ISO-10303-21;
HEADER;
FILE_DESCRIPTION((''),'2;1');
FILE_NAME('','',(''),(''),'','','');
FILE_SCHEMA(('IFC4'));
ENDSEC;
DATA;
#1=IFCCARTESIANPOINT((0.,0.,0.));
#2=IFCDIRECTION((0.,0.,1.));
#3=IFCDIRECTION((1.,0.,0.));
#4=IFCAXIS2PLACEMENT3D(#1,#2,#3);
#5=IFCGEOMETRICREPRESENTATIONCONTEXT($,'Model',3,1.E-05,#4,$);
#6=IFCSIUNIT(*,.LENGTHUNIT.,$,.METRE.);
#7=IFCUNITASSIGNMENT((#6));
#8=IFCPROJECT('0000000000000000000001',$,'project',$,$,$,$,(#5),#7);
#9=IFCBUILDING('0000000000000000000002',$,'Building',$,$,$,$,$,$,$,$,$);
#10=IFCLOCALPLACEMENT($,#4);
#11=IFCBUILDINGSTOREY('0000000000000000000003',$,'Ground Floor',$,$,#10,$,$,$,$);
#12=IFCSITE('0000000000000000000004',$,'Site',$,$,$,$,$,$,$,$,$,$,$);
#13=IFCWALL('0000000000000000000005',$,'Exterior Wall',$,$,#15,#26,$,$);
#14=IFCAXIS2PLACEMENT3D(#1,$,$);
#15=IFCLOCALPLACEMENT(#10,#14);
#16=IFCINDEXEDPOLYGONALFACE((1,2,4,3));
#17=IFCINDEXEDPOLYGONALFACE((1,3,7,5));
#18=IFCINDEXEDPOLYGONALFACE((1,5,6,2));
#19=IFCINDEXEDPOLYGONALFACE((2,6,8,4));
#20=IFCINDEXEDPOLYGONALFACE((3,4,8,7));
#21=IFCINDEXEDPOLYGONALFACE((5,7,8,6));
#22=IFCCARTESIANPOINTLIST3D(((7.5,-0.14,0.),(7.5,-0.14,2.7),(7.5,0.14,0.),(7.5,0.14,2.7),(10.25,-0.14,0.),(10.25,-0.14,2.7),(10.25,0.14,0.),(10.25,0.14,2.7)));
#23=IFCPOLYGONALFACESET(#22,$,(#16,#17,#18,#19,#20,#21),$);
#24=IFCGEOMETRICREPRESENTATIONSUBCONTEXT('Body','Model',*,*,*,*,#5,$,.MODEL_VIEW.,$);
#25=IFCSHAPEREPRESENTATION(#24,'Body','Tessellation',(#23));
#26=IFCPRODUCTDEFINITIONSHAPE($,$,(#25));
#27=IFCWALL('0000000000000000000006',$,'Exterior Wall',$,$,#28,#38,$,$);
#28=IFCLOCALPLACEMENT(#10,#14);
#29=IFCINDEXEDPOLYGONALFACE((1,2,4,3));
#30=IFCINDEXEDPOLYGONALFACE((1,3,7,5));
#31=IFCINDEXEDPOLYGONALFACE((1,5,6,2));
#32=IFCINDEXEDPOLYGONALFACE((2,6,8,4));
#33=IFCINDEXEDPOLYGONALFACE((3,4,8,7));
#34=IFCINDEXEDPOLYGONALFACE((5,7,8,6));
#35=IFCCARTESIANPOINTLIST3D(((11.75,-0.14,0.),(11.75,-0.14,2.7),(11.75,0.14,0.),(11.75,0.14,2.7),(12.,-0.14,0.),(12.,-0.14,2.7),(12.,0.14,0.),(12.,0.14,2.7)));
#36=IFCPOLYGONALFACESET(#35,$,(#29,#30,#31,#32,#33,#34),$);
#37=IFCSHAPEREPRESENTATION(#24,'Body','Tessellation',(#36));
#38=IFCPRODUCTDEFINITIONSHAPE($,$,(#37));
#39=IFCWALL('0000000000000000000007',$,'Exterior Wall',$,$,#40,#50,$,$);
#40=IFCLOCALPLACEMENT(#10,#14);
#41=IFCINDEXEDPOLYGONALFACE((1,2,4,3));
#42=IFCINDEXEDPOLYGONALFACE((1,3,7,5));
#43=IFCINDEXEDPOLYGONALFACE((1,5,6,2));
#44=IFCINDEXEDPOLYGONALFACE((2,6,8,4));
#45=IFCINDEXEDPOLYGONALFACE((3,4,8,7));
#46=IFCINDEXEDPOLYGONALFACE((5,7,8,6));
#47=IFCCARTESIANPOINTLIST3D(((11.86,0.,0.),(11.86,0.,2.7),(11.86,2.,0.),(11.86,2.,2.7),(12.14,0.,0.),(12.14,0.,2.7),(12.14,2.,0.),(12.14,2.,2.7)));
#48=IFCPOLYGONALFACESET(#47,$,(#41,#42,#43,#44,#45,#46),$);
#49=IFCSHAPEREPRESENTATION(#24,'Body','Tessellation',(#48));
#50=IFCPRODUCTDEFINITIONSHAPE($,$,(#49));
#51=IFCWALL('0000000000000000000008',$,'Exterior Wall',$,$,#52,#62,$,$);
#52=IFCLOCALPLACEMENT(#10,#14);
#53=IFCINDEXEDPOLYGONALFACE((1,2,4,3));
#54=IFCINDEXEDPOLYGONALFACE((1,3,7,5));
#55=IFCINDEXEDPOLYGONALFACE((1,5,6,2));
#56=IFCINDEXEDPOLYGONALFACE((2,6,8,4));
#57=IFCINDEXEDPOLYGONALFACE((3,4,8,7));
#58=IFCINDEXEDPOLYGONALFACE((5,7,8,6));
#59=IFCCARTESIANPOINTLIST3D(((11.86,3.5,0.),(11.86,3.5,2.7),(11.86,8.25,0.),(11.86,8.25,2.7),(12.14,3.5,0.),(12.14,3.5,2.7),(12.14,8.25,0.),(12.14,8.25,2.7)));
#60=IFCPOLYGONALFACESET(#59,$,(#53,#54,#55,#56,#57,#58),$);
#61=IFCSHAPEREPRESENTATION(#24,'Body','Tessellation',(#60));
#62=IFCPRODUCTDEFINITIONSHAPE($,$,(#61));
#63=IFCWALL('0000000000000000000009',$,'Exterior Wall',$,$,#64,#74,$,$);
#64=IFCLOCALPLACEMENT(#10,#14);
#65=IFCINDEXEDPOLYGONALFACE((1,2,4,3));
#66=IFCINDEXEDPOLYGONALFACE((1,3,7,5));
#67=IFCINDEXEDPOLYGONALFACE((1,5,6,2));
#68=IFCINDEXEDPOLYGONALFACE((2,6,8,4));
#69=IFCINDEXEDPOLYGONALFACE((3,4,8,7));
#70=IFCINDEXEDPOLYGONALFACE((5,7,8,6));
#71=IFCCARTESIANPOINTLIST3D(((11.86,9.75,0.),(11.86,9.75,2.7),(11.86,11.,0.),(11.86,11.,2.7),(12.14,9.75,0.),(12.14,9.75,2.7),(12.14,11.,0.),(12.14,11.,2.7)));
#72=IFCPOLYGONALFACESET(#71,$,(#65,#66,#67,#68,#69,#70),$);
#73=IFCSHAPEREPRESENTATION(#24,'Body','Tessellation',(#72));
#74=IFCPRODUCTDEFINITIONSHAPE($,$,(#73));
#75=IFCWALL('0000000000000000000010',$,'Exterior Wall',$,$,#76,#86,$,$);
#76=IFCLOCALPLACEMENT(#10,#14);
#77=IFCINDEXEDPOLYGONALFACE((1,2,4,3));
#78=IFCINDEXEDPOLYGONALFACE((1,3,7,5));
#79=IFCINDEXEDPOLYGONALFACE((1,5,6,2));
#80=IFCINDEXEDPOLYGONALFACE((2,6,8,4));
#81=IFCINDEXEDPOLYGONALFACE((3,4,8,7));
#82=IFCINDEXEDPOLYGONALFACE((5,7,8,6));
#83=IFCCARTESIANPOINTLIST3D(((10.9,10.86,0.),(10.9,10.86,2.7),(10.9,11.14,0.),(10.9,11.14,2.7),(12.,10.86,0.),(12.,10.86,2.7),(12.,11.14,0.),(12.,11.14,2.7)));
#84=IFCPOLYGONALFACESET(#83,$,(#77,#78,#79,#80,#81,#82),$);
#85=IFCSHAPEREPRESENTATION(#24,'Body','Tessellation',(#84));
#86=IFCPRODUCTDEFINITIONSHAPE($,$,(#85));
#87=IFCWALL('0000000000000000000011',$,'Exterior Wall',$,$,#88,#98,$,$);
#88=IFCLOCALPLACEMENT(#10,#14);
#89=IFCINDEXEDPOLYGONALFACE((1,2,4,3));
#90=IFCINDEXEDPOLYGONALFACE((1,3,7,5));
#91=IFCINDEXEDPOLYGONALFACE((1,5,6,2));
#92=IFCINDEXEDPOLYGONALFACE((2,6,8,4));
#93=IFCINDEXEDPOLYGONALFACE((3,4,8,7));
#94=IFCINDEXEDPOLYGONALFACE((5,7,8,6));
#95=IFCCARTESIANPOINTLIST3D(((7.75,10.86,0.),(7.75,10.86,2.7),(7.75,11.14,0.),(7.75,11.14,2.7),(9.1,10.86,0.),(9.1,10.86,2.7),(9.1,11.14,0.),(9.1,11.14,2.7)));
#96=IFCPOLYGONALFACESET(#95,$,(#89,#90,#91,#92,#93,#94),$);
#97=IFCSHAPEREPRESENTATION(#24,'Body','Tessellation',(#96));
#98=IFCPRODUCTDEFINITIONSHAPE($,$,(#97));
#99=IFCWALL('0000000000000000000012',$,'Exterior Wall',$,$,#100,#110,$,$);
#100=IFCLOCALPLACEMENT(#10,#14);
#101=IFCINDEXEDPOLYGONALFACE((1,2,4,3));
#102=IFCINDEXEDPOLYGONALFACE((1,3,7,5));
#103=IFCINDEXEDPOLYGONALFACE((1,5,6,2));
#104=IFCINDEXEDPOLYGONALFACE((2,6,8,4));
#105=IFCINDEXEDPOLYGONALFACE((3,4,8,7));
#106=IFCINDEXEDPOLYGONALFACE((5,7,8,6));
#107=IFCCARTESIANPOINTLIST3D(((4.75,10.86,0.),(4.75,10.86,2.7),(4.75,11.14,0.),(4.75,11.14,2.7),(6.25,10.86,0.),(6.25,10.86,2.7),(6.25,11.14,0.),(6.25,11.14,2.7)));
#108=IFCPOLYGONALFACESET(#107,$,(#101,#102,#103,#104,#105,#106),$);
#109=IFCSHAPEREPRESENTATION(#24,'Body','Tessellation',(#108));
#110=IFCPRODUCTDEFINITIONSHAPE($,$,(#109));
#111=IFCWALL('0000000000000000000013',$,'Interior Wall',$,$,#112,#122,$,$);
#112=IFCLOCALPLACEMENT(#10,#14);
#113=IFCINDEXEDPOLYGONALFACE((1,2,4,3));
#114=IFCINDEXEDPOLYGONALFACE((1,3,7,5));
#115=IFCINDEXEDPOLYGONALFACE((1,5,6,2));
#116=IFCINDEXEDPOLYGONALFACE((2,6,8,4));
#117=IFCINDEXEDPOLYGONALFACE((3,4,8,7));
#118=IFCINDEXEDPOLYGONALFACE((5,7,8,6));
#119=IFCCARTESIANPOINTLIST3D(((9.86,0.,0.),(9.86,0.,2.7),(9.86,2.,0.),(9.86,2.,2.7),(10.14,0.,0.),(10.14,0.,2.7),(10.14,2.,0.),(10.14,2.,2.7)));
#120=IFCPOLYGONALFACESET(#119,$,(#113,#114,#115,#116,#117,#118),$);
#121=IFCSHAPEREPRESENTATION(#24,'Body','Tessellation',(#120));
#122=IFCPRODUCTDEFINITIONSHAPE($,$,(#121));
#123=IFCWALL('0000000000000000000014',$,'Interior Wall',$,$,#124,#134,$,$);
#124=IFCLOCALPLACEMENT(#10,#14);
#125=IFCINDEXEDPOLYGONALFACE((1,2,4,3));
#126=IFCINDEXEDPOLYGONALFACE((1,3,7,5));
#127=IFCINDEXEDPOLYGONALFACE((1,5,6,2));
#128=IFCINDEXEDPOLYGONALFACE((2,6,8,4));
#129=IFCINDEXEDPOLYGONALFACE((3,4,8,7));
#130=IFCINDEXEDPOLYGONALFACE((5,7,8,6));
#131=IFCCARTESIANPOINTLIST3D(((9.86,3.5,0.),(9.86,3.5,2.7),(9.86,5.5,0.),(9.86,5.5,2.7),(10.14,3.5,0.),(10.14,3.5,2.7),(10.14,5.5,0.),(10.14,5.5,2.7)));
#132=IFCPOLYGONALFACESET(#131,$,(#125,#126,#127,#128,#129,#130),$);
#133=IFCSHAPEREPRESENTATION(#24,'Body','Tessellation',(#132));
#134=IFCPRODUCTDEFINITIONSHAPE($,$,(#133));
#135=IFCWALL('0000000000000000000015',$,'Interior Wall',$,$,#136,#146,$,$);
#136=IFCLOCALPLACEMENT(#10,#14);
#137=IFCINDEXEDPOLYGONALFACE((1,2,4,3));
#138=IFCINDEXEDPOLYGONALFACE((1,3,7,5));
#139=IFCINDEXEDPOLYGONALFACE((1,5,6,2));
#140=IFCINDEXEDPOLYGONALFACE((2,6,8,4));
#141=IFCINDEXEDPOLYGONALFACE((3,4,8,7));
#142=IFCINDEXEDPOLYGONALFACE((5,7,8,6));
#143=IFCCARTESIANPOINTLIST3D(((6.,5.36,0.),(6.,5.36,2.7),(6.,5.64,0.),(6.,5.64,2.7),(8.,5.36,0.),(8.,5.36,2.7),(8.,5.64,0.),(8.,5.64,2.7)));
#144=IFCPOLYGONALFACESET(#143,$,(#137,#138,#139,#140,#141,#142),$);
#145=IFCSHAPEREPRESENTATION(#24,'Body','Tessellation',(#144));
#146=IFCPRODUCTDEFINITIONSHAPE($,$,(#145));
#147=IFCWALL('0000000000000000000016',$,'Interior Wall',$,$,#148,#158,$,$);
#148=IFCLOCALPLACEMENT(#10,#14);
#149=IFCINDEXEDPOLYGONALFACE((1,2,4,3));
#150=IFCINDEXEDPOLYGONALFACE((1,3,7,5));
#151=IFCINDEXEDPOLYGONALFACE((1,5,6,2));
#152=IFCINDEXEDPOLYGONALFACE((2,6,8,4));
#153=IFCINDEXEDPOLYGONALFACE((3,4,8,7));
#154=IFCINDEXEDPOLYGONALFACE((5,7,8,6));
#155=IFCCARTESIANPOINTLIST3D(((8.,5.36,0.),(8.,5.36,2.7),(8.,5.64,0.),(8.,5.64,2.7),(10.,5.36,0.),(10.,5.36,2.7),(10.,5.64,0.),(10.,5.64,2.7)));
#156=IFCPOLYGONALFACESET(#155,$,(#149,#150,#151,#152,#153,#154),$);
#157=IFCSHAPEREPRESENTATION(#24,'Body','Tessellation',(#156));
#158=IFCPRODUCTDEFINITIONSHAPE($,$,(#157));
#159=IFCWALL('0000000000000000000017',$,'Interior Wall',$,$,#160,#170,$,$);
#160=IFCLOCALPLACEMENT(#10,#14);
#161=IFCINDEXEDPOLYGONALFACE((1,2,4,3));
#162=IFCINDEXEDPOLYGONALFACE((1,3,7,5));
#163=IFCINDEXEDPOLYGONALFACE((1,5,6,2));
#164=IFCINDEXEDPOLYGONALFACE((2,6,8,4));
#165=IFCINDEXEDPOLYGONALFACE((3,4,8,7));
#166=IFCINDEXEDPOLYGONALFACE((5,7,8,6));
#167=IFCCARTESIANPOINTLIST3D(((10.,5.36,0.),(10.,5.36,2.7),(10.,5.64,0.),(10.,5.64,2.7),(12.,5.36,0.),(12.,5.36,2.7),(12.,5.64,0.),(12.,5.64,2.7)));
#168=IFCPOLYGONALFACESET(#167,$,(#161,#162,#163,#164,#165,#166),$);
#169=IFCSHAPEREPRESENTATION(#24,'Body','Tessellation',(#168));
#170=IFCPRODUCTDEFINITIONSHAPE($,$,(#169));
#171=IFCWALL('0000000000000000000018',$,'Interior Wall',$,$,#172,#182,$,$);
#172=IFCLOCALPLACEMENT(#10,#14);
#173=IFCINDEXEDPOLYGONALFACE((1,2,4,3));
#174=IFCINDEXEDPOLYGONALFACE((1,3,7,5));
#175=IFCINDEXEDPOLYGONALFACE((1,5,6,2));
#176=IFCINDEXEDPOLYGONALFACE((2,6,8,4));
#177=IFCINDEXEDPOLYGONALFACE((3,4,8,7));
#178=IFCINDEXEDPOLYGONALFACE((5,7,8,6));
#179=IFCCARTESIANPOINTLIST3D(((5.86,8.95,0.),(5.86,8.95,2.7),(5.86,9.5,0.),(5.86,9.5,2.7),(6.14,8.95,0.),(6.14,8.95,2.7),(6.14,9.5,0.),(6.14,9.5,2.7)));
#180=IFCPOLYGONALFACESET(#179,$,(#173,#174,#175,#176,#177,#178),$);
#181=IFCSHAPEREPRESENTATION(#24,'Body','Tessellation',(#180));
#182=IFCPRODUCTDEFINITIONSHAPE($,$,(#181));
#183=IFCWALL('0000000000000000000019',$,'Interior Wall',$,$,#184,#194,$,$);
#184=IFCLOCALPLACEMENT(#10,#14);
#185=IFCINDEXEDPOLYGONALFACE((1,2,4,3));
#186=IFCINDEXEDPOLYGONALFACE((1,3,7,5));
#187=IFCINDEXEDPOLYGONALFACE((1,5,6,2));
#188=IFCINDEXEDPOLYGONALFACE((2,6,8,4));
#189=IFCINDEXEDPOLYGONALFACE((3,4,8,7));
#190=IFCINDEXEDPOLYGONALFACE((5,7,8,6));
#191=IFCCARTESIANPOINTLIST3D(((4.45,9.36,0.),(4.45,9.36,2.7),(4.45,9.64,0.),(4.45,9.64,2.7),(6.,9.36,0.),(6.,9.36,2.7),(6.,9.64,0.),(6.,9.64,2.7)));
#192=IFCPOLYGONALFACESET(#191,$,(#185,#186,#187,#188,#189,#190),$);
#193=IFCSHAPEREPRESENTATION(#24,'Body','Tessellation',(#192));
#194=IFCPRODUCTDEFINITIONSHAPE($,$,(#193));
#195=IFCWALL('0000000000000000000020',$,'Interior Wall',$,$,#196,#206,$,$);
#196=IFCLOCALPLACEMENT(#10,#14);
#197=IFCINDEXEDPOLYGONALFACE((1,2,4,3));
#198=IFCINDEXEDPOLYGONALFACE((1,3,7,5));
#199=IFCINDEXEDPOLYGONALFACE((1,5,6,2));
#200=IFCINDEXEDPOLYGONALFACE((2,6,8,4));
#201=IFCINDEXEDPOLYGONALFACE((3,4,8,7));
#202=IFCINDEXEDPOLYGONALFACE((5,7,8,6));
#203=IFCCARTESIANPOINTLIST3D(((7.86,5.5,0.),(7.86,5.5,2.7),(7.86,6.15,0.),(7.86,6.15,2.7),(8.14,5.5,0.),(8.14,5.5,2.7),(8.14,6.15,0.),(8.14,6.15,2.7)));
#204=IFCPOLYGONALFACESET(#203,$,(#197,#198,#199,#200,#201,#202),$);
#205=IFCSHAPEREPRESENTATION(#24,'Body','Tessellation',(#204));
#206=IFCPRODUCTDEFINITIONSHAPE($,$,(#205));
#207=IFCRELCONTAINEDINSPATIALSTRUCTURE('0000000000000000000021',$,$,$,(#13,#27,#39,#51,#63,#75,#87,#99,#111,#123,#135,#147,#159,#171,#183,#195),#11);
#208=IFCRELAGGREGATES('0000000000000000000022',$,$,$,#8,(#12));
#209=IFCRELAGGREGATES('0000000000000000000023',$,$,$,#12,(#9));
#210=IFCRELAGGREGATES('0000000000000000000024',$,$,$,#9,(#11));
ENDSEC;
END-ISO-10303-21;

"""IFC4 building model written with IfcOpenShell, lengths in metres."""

from ifc_helpers import new_model, si_unit, frame, origin_with_axes, place, context, subcontext, project, spatial, indexed_curve, outline, extrude, element, save


model = new_model("IFC4")

# Units and contexts
model_context = context("Model", 3, precision=1e-05, world=origin_with_axes())
body_context = subcontext(model_context, "Body", "Model", "MODEL_VIEW")
ifc_project = project(units=[si_unit("LENGTHUNIT", "METRE")], contexts=[model_context])

# Site, building, storey
site = spatial("IfcSite", under=ifc_project, Name="Site")
building = spatial("IfcBuilding", under=site, Name="Building")
storey_placement = place(None, origin_with_axes())
storey = spatial("IfcBuildingStorey", under=building, at=storey_placement, Name="Ground Floor")

# Walls
wall_1_placement = place(storey_placement, frame((7.5, 0.0, 0.0), z_axis=(0.0, 0.0, 1.0), x_axis=(1.0, 0.0, 0.0)))
element("IfcWall", 1, at=wall_1_placement, inside=storey, Name="Exterior Wall", context=body_context, shape_type="SweptSolid", body=[
    extrude(outline(indexed_curve([(0.0, 0.0), (0.0, 0.28), (2.75, 0.28), (2.75, 0.0), (0.0, 0.0)], self_intersect=False)), frame((0.0, -0.14, 0.0), z_axis=(0.0, 0.0, 1.0), x_axis=(1.0, 0.0, 0.0)), (0.0, 0.0, 1.0), 2.7),
])
wall_2_placement = place(storey_placement, frame((11.75, 0.0, 0.0), z_axis=(0.0, 0.0, 1.0), x_axis=(1.0, 0.0, 0.0)))
element("IfcWall", 2, at=wall_2_placement, inside=storey, Name="Exterior Wall", context=body_context, shape_type="SweptSolid", body=[
    extrude(outline(indexed_curve([(0.0, 0.0), (0.0, 0.28), (0.25, 0.28), (0.25, 0.0), (0.0, 0.0)], self_intersect=False)), frame((0.0, -0.14, 0.0), z_axis=(0.0, 0.0, 1.0), x_axis=(1.0, 0.0, 0.0)), (0.0, 0.0, 1.0), 2.7),
])
wall_3_placement = place(storey_placement, frame((12.0, 0.0, 0.0), z_axis=(0.0, 0.0, 1.0), x_axis=(0.0, 1.0, 0.0)))
element("IfcWall", 3, at=wall_3_placement, inside=storey, Name="Exterior Wall", context=body_context, shape_type="SweptSolid", body=[
    extrude(outline(indexed_curve([(0.0, 0.0), (0.0, 0.28), (2.0, 0.28), (2.0, 0.0), (0.0, 0.0)], self_intersect=False)), frame((0.0, -0.14, 0.0), z_axis=(0.0, 0.0, 1.0), x_axis=(1.0, 0.0, 0.0)), (0.0, 0.0, 1.0), 2.7),
])
wall_4_placement = place(storey_placement, frame((12.0, 3.5, 0.0), z_axis=(0.0, 0.0, 1.0), x_axis=(0.0, 1.0, 0.0)))
element("IfcWall", 4, at=wall_4_placement, inside=storey, Name="Exterior Wall", context=body_context, shape_type="SweptSolid", body=[
    extrude(outline(indexed_curve([(0.0, 0.0), (0.0, 0.28), (4.75, 0.28), (4.75, 0.0), (0.0, 0.0)], self_intersect=False)), frame((0.0, -0.14, 0.0), z_axis=(0.0, 0.0, 1.0), x_axis=(1.0, 0.0, 0.0)), (0.0, 0.0, 1.0), 2.7),
])
wall_5_placement = place(storey_placement, frame((12.0, 9.75, 0.0), z_axis=(0.0, 0.0, 1.0), x_axis=(0.0, 1.0, 0.0)))
element("IfcWall", 5, at=wall_5_placement, inside=storey, Name="Exterior Wall", context=body_context, shape_type="SweptSolid", body=[
    extrude(outline(indexed_curve([(0.0, 0.0), (0.0, 0.28), (1.25, 0.28), (1.25, 0.0), (0.0, 0.0)], self_intersect=False)), frame((0.0, -0.14, 0.0), z_axis=(0.0, 0.0, 1.0), x_axis=(1.0, 0.0, 0.0)), (0.0, 0.0, 1.0), 2.7),
])
wall_6_placement = place(storey_placement, frame((12.0, 11.0, 0.0), z_axis=(0.0, 0.0, 1.0), x_axis=(-1.0, 0.0, 0.0)))
element("IfcWall", 6, at=wall_6_placement, inside=storey, Name="Exterior Wall", context=body_context, shape_type="SweptSolid", body=[
    extrude(outline(indexed_curve([(0.0, 0.0), (0.0, 0.28), (1.1, 0.28), (1.1, 0.0), (0.0, 0.0)], self_intersect=False)), frame((0.0, -0.14, 0.0), z_axis=(0.0, 0.0, 1.0), x_axis=(1.0, 0.0, 0.0)), (0.0, 0.0, 1.0), 2.7),
])
wall_7_placement = place(storey_placement, frame((9.1, 11.0, 0.0), z_axis=(0.0, 0.0, 1.0), x_axis=(-1.0, 0.0, 0.0)))
element("IfcWall", 7, at=wall_7_placement, inside=storey, Name="Exterior Wall", context=body_context, shape_type="SweptSolid", body=[
    extrude(outline(indexed_curve([(0.0, 0.0), (0.0, 0.28), (1.35, 0.28), (1.35, 0.0), (0.0, 0.0)], self_intersect=False)), frame((0.0, -0.14, 0.0), z_axis=(0.0, 0.0, 1.0), x_axis=(1.0, 0.0, 0.0)), (0.0, 0.0, 1.0), 2.7),
])
wall_8_placement = place(storey_placement, frame((6.25, 11.0, 0.0), z_axis=(0.0, 0.0, 1.0), x_axis=(-1.0, 0.0, 0.0)))
element("IfcWall", 8, at=wall_8_placement, inside=storey, Name="Exterior Wall", context=body_context, shape_type="SweptSolid", body=[
    extrude(outline(indexed_curve([(0.0, 0.0), (0.0, 0.28), (1.5, 0.28), (1.5, 0.0), (0.0, 0.0)], self_intersect=False)), frame((0.0, -0.14, 0.0), z_axis=(0.0, 0.0, 1.0), x_axis=(1.0, 0.0, 0.0)), (0.0, 0.0, 1.0), 2.7),
])
for number, where, z_axis, x_axis, name in (
    (9, (10.0, 0.0, 0.0), (0.0, 0.0, 1.0), (0.0, 1.0, 0.0), "Interior Wall"),
    (10, (10.0, 3.5, 0.0), (0.0, 0.0, 1.0), (0.0, 1.0, 0.0), "Interior Wall"),
    (11, (8.0, 5.5, 0.0), (0.0, 0.0, 1.0), (-1.0, 0.0, 0.0), "Interior Wall"),
    (12, (10.0, 5.5, 0.0), (0.0, 0.0, 1.0), (-1.0, 0.0, 0.0), "Interior Wall"),
    (13, (12.0, 5.5, 0.0), (0.0, 0.0, 1.0), (-1.0, 0.0, 0.0), "Interior Wall"),
):
    element("IfcWall", number, at=place(storey_placement, frame(where, z_axis=z_axis, x_axis=x_axis)), inside=storey, Name=name, context=body_context, shape_type="SweptSolid", body=[
        extrude(outline(indexed_curve([(0.0, 0.0), (0.0, 0.28), (2.0, 0.28), (2.0, 0.0), (0.0, 0.0)], self_intersect=False)), frame((0.0, -0.14, 0.0), z_axis=(0.0, 0.0, 1.0), x_axis=(1.0, 0.0, 0.0)), (0.0, 0.0, 1.0), 2.7),
    ])
wall_9_placement = place(storey_placement, frame((6.0, 8.95, 0.0), z_axis=(0.0, 0.0, 1.0), x_axis=(0.0, 1.0, 0.0)))
element("IfcWall", 14, at=wall_9_placement, inside=storey, Name="Interior Wall", context=body_context, shape_type="SweptSolid", body=[
    extrude(outline(indexed_curve([(0.0, 0.0), (0.0, 0.28), (0.55, 0.28), (0.55, 0.0), (0.0, 0.0)], self_intersect=False)), frame((0.0, -0.14, 0.0), z_axis=(0.0, 0.0, 1.0), x_axis=(1.0, 0.0, 0.0)), (0.0, 0.0, 1.0), 2.7),
])
wall_10_placement = place(storey_placement, frame((6.0, 9.5, 0.0), z_axis=(0.0, 0.0, 1.0), x_axis=(-1.0, 0.0, 0.0)))
element("IfcWall", 15, at=wall_10_placement, inside=storey, Name="Interior Wall", context=body_context, shape_type="SweptSolid", body=[
    extrude(outline(indexed_curve([(0.0, 0.0), (0.0, 0.28), (1.55, 0.28), (1.55, 0.0), (0.0, 0.0)], self_intersect=False)), frame((0.0, -0.14, 0.0), z_axis=(0.0, 0.0, 1.0), x_axis=(1.0, 0.0, 0.0)), (0.0, 0.0, 1.0), 2.7),
])
wall_11_placement = place(storey_placement, frame((8.0, 5.5, 0.0), z_axis=(0.0, 0.0, 1.0), x_axis=(0.0, 1.0, 0.0)))
element("IfcWall", 16, at=wall_11_placement, inside=storey, Name="Interior Wall", context=body_context, shape_type="SweptSolid", body=[
    extrude(outline(indexed_curve([(0.0, 0.0), (0.0, 0.28), (0.65, 0.28), (0.65, 0.0), (0.0, 0.0)], self_intersect=False)), frame((0.0, -0.14, 0.0), z_axis=(0.0, 0.0, 1.0), x_axis=(1.0, 0.0, 0.0)), (0.0, 0.0, 1.0), 2.7),
])

save(model, "model.ifc")
